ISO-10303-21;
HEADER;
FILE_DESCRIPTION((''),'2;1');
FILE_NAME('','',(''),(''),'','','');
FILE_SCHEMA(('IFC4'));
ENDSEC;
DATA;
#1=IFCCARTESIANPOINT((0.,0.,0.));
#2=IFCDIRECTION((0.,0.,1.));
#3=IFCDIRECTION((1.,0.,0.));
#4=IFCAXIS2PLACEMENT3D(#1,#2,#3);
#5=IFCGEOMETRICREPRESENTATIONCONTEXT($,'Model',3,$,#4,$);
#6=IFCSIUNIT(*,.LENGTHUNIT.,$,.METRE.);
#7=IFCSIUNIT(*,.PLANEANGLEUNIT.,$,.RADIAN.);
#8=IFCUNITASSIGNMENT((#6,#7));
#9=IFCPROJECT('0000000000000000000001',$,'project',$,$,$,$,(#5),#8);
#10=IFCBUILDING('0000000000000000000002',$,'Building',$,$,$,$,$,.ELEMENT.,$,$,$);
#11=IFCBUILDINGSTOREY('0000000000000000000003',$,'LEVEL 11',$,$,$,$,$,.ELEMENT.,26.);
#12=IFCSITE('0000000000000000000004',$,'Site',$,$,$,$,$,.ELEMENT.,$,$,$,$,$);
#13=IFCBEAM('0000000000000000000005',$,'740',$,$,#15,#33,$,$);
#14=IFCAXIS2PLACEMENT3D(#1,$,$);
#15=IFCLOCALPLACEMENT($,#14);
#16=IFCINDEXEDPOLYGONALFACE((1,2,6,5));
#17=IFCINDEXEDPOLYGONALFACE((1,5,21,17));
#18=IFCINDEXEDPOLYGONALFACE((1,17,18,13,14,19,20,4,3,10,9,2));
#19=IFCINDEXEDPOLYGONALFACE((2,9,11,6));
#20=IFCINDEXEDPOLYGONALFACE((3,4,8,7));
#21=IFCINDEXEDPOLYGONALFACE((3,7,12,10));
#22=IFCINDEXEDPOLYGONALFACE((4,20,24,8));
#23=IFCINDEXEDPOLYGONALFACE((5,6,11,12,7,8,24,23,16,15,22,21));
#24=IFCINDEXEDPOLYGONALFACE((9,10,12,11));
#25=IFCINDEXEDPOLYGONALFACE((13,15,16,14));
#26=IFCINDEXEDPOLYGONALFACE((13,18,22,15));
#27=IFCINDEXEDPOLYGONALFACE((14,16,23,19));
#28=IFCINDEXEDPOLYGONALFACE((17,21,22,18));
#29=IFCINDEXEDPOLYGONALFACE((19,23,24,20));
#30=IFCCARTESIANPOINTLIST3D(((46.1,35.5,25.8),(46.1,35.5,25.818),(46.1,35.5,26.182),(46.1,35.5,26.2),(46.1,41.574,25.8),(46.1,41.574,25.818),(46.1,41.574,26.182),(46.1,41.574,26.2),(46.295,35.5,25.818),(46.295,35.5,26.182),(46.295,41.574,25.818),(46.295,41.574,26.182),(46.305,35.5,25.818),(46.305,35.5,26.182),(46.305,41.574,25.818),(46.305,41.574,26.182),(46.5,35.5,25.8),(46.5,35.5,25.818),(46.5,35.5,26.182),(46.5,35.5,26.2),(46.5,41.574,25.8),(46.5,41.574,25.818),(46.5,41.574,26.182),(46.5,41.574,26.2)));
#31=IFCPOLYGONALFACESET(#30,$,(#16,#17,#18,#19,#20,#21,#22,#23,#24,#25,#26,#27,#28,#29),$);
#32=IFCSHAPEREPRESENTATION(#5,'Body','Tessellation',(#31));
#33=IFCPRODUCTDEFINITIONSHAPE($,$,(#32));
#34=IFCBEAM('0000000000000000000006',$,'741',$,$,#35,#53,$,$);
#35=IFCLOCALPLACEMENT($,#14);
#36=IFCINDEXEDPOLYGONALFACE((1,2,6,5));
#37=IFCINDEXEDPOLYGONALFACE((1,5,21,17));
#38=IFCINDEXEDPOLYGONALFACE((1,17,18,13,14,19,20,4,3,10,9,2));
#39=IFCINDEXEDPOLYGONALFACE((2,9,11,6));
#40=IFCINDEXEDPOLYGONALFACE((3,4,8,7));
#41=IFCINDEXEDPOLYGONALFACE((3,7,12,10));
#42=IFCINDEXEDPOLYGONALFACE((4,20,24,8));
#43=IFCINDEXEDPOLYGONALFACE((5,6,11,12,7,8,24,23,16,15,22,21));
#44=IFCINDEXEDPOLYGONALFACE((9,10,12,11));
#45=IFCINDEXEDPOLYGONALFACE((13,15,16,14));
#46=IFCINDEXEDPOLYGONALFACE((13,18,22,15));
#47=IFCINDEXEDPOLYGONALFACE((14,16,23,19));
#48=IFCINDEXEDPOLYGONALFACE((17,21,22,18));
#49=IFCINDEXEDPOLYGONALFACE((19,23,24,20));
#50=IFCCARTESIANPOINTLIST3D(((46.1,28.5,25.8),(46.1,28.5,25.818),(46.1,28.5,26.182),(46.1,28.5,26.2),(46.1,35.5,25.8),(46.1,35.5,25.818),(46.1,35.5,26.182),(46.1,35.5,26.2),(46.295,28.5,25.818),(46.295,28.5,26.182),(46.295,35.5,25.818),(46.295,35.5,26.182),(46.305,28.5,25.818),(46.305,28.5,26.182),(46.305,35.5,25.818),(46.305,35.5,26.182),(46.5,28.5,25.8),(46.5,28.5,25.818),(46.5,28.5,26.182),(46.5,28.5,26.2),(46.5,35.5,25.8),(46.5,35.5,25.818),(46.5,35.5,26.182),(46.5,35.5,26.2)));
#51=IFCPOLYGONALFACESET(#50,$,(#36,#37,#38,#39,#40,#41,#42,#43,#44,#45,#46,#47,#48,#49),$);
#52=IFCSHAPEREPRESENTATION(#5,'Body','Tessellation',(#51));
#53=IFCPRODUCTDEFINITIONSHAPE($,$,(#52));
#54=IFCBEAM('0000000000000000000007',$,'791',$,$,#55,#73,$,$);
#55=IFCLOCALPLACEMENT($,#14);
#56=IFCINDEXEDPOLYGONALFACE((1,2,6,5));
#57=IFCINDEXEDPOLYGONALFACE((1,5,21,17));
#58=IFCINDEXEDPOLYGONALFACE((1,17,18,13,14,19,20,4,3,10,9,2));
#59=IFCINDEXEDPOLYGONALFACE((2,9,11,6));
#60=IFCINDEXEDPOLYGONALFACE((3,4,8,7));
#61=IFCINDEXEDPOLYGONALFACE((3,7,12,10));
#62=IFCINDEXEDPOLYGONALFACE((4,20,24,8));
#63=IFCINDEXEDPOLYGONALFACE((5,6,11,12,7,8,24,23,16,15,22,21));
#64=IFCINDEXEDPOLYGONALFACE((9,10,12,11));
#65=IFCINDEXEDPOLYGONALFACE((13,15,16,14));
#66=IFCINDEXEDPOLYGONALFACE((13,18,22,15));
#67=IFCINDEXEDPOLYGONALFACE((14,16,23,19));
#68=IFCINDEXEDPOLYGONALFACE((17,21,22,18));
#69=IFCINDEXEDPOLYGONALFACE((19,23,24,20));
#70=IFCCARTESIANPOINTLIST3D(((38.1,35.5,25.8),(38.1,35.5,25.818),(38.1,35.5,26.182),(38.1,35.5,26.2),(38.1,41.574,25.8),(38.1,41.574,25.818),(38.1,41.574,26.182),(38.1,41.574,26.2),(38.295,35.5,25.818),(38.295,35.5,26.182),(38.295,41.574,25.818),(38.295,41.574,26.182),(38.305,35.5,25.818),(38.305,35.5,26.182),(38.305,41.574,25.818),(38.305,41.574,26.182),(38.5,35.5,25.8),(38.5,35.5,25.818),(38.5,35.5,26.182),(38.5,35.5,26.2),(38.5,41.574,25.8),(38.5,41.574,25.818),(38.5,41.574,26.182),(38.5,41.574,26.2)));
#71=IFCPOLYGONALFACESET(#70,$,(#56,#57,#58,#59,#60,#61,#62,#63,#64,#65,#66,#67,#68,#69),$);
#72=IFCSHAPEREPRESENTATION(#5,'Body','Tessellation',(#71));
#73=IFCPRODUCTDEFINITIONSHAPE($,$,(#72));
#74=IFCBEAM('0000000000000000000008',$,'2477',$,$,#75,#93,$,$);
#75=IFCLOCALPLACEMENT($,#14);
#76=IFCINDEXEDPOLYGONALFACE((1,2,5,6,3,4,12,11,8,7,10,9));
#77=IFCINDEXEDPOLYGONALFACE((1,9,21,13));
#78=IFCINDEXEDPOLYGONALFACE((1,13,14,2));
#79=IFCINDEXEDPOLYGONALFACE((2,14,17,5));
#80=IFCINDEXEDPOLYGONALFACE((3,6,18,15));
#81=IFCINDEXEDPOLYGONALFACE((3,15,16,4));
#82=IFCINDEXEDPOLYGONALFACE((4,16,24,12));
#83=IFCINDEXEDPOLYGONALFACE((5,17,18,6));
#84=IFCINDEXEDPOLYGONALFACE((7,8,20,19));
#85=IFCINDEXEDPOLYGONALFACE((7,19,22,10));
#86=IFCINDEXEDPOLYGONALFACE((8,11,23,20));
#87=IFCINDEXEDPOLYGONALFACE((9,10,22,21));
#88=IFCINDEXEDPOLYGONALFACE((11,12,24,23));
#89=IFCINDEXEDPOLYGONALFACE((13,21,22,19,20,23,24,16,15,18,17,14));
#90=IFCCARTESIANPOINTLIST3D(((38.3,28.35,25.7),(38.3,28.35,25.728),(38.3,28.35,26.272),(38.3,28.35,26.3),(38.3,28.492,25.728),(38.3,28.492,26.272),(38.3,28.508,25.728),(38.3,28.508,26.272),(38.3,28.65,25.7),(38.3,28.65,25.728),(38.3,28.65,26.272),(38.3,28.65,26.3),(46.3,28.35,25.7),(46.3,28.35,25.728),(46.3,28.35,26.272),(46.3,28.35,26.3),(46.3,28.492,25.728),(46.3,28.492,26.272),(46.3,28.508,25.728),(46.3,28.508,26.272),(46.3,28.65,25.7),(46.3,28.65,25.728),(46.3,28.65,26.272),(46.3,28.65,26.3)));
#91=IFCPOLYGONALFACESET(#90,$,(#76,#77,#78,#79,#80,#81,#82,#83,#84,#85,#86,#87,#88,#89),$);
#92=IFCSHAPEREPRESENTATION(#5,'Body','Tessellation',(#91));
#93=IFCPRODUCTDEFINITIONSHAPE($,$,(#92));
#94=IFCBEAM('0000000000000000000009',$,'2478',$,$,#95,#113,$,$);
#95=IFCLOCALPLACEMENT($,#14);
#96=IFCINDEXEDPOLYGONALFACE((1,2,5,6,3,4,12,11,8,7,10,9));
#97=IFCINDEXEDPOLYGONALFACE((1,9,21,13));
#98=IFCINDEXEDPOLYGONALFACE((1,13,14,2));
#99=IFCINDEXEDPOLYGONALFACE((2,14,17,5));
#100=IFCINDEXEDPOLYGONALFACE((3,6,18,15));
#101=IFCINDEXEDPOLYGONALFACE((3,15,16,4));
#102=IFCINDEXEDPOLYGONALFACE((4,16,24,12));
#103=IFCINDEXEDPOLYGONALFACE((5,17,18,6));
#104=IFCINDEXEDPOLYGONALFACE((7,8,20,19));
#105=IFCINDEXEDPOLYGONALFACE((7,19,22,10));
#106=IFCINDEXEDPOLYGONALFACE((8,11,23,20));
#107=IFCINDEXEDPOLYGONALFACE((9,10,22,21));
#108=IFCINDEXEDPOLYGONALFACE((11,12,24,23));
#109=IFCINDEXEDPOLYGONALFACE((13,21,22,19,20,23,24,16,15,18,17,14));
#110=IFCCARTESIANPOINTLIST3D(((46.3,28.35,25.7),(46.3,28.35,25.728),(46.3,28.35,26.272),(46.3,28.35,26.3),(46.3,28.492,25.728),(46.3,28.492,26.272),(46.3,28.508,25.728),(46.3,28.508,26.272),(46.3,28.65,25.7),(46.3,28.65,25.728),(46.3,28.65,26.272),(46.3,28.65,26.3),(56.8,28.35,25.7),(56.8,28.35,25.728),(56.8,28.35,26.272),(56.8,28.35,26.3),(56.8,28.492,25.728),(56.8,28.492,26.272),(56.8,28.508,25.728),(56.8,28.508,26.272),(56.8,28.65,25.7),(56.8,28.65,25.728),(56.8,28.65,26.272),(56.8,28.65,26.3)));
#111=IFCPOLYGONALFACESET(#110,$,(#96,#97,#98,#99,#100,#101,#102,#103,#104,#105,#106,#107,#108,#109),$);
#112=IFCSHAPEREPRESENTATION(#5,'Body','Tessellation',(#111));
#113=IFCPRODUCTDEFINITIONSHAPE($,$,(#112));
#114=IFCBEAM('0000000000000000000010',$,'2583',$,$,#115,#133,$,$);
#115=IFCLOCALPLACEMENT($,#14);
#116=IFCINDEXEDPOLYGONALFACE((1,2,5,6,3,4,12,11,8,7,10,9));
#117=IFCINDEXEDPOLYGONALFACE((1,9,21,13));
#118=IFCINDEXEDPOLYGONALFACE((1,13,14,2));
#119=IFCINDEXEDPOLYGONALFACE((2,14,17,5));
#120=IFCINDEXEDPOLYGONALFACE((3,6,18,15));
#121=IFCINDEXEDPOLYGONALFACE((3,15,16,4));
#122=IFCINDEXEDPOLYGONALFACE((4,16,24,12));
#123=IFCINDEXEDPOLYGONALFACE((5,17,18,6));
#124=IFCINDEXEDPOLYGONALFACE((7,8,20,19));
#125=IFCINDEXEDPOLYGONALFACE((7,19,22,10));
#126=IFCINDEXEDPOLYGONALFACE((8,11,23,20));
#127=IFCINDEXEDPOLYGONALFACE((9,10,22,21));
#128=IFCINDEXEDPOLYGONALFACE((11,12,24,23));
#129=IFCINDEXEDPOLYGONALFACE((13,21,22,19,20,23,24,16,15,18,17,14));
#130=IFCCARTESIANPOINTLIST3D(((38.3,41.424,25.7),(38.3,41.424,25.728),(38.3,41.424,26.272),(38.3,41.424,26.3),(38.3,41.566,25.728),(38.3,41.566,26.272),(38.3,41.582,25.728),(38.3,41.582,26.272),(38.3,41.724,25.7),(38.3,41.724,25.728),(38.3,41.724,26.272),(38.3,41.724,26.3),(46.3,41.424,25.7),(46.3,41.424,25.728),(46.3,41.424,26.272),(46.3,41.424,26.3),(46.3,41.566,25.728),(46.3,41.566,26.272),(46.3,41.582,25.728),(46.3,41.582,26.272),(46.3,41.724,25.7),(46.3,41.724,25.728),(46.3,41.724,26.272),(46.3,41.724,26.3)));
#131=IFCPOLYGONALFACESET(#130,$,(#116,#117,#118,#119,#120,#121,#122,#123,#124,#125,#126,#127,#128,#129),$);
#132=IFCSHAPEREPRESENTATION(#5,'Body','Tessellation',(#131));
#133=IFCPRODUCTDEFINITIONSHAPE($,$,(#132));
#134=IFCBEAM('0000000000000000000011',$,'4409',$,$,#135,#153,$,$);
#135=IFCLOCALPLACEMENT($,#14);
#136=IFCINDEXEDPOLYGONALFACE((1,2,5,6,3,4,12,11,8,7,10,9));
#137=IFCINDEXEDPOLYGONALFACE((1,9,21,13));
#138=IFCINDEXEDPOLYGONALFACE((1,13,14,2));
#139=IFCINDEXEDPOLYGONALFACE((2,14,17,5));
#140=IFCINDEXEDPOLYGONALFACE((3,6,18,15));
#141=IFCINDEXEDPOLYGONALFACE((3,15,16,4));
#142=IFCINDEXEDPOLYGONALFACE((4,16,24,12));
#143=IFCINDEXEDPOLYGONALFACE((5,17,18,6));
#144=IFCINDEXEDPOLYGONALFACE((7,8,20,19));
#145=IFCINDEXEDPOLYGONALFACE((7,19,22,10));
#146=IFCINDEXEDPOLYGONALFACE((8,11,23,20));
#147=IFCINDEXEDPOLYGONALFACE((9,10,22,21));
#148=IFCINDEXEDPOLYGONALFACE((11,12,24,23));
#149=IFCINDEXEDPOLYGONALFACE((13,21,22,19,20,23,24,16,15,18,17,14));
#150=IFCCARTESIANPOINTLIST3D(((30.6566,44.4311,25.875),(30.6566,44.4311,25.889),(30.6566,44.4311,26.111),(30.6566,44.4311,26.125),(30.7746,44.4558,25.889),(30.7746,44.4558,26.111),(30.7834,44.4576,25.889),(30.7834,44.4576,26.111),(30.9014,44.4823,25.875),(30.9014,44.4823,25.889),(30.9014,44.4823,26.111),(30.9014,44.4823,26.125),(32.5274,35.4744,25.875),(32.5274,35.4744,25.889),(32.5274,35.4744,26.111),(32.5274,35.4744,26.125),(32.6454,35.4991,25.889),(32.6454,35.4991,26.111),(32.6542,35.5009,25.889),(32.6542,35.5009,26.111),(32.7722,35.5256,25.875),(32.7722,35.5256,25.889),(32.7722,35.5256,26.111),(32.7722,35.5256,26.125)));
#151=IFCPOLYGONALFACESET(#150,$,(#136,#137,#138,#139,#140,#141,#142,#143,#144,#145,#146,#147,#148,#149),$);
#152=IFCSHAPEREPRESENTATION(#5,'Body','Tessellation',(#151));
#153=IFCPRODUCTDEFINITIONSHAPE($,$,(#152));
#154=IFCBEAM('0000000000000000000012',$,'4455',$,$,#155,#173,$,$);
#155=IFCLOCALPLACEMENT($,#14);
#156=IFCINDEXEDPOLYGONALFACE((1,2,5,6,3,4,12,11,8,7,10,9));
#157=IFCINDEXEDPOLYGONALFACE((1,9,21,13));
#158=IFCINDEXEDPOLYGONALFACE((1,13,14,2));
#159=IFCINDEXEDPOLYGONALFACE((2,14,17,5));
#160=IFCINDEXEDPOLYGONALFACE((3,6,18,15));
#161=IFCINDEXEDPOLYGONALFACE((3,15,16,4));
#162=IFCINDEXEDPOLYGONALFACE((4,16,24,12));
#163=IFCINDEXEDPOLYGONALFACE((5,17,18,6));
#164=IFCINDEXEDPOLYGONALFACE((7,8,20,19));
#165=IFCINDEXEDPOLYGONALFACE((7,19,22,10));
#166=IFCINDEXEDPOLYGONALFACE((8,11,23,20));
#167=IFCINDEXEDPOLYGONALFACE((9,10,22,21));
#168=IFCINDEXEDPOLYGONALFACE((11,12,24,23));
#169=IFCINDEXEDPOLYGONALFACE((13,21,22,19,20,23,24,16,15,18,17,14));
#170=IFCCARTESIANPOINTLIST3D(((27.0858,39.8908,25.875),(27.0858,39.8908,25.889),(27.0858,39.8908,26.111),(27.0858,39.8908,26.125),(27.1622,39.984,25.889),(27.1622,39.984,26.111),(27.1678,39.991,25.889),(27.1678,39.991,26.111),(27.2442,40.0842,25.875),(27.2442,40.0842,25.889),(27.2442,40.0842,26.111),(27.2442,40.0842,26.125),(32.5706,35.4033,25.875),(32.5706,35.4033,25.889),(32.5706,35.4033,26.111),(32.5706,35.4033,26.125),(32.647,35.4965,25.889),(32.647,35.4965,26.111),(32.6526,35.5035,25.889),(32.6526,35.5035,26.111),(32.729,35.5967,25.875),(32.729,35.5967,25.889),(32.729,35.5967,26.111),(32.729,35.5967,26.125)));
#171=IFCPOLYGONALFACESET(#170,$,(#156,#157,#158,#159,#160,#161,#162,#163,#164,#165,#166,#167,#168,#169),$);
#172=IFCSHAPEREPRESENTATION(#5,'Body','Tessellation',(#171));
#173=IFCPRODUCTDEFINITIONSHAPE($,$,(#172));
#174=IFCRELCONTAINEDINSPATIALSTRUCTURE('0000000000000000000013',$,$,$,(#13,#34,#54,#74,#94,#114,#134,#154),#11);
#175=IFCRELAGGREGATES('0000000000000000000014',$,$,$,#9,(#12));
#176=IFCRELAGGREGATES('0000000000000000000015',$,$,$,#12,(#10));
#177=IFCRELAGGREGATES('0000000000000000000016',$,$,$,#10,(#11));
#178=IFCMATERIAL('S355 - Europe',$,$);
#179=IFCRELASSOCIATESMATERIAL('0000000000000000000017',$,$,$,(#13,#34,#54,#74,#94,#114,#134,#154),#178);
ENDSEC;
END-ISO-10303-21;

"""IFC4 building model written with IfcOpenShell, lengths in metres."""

from ifc_helpers import new_model, si_unit, frame, origin_with_axes, origin_2d_with_axis, place, context, project, spatial, i_section, extrude, material, material_profile, profile_set, profile_usage, element, save


model = new_model("IFC4")

# Units and contexts
model_context = context("Model", 3, world=origin_with_axes())
ifc_project = project(units=[si_unit("LENGTHUNIT", "METRE"), si_unit("PLANEANGLEUNIT", "RADIAN")], contexts=[model_context])

# Site, building, storey
site = spatial("IfcSite", under=ifc_project, Name="Site", CompositionType="ELEMENT")
building = spatial("IfcBuilding", under=site, Name="Building", CompositionType="ELEMENT")
storey = spatial("IfcBuildingStorey", under=building, Name="LEVEL 11", CompositionType="ELEMENT", Elevation=26.0)

# Shared definitions
ifc_material = material(Name="S355 - Europe")

# Beams
ifc_material_profile_1 = material_profile(ifc_material, i_section(OverallWidth=0.4, OverallDepth=0.4, WebThickness=0.01, FlangeThickness=0.018, at=origin_2d_with_axis()))
ifc_profile_set_1 = profile_set([ifc_material_profile_1])
ifc_profile_usage_1 = profile_usage(ifc_profile_set_1, cardinal=10)
beam_1_placement = place(None, frame((46.3, 35.5, 26.0), z_axis=(0.0, 1.0, 0.0), x_axis=(-1.0, 0.0, 0.0)))
element("IfcBeam", 1, at=beam_1_placement, inside=storey, material=ifc_profile_usage_1, Name="740", context=model_context, shape_type="SweptSolid", body=[
    extrude(i_section(OverallWidth=0.4, OverallDepth=0.4, WebThickness=0.01, FlangeThickness=0.018, at=origin_2d_with_axis()), origin_with_axes(), (0.0, 0.0, 1.0), 6.074),
])
ifc_material_profile_2 = material_profile(ifc_material, i_section(OverallWidth=0.4, OverallDepth=0.4, WebThickness=0.01, FlangeThickness=0.018, at=origin_2d_with_axis()))
ifc_profile_set_2 = profile_set([ifc_material_profile_2])
ifc_profile_usage_2 = profile_usage(ifc_profile_set_2, cardinal=10)
beam_2_placement = place(None, frame((46.3, 28.5, 26.0), z_axis=(0.0, 1.0, 0.0), x_axis=(-1.0, 0.0, 0.0)))
element("IfcBeam", 2, at=beam_2_placement, inside=storey, material=ifc_profile_usage_2, Name="741", context=model_context, shape_type="SweptSolid", body=[
    extrude(i_section(OverallWidth=0.4, OverallDepth=0.4, WebThickness=0.01, FlangeThickness=0.018, at=origin_2d_with_axis()), origin_with_axes(), (0.0, 0.0, 1.0), 7.0),
])
ifc_material_profile_3 = material_profile(ifc_material, i_section(OverallWidth=0.4, OverallDepth=0.4, WebThickness=0.01, FlangeThickness=0.018, at=origin_2d_with_axis()))
ifc_profile_set_3 = profile_set([ifc_material_profile_3])
ifc_profile_usage_3 = profile_usage(ifc_profile_set_3, cardinal=10)
beam_3_placement = place(None, frame((38.3, 41.574, 26.0), z_axis=(0.0, -1.0, 0.0), x_axis=(1.0, 0.0, 0.0)))
element("IfcBeam", 3, at=beam_3_placement, inside=storey, material=ifc_profile_usage_3, Name="791", context=model_context, shape_type="SweptSolid", body=[
    extrude(i_section(OverallWidth=0.4, OverallDepth=0.4, WebThickness=0.01, FlangeThickness=0.018, at=origin_2d_with_axis()), origin_with_axes(), (0.0, 0.0, 1.0), 6.074),
])
ifc_material_profile_4 = material_profile(ifc_material, i_section(OverallWidth=0.3, OverallDepth=0.6, WebThickness=0.016, FlangeThickness=0.028, at=origin_2d_with_axis()))
ifc_profile_set_4 = profile_set([ifc_material_profile_4])
ifc_profile_usage_4 = profile_usage(ifc_profile_set_4, cardinal=10)
beam_4_placement = place(None, frame((38.3, 28.5, 26.0), z_axis=(1.0, 0.0, 0.0), x_axis=(0.0, 1.0, 0.0)))
element("IfcBeam", 4, at=beam_4_placement, inside=storey, material=ifc_profile_usage_4, Name="2477", context=model_context, shape_type="SweptSolid", body=[
    extrude(i_section(OverallWidth=0.3, OverallDepth=0.6, WebThickness=0.016, FlangeThickness=0.028, at=origin_2d_with_axis()), origin_with_axes(), (0.0, 0.0, 1.0), 8.0),
])
ifc_material_profile_5 = material_profile(ifc_material, i_section(OverallWidth=0.3, OverallDepth=0.6, WebThickness=0.016, FlangeThickness=0.028, at=origin_2d_with_axis()))
ifc_profile_set_5 = profile_set([ifc_material_profile_5])
ifc_profile_usage_5 = profile_usage(ifc_profile_set_5, cardinal=10)
beam_5_placement = place(None, frame((46.3, 28.5, 26.0), z_axis=(1.0, 0.0, 0.0), x_axis=(0.0, 1.0, 0.0)))
element("IfcBeam", 5, at=beam_5_placement, inside=storey, material=ifc_profile_usage_5, Name="2478", context=model_context, shape_type="SweptSolid", body=[
    extrude(i_section(OverallWidth=0.3, OverallDepth=0.6, WebThickness=0.016, FlangeThickness=0.028, at=origin_2d_with_axis()), origin_with_axes(), (0.0, 0.0, 1.0), 10.5),
])
ifc_material_profile_6 = material_profile(ifc_material, i_section(OverallWidth=0.3, OverallDepth=0.6, WebThickness=0.016, FlangeThickness=0.028, at=origin_2d_with_axis()))
ifc_profile_set_6 = profile_set([ifc_material_profile_6])
ifc_profile_usage_6 = profile_usage(ifc_profile_set_6, cardinal=10)
beam_6_placement = place(None, frame((38.3, 41.574, 26.0), z_axis=(1.0, 0.0, 0.0), x_axis=(0.0, 1.0, 0.0)))
element("IfcBeam", 6, at=beam_6_placement, inside=storey, material=ifc_profile_usage_6, Name="2583", context=model_context, shape_type="SweptSolid", body=[
    extrude(i_section(OverallWidth=0.3, OverallDepth=0.6, WebThickness=0.016, FlangeThickness=0.028, at=origin_2d_with_axis()), origin_with_axes(), (0.0, 0.0, 1.0), 8.0),
])
ifc_material_profile_7 = material_profile(ifc_material, i_section(OverallWidth=0.25, OverallDepth=0.25, WebThickness=0.009, FlangeThickness=0.014, at=origin_2d_with_axis()))
ifc_profile_set_7 = profile_set([ifc_material_profile_7])
ifc_profile_usage_7 = profile_usage(ifc_profile_set_7, cardinal=10)
beam_7_placement = place(None, frame((32.6498, 35.5, 26.0), z_axis=(-0.204459, 0.978875, 0.0), x_axis=(-0.978875, -0.204459, 0.0)))
element("IfcBeam", 7, at=beam_7_placement, inside=storey, material=ifc_profile_usage_7, Name="4409", context=model_context, shape_type="SweptSolid", body=[
    extrude(i_section(OverallWidth=0.25, OverallDepth=0.25, WebThickness=0.009, FlangeThickness=0.014, at=origin_2d_with_axis()), origin_with_axes(), (0.0, 0.0, 1.0), 9.15),
])
ifc_material_profile_8 = material_profile(ifc_material, i_section(OverallWidth=0.25, OverallDepth=0.25, WebThickness=0.009, FlangeThickness=0.014, at=origin_2d_with_axis()))
ifc_profile_set_8 = profile_set([ifc_material_profile_8])
ifc_profile_usage_8 = profile_usage(ifc_profile_set_8, cardinal=10)
beam_8_placement = place(None, frame((32.6498, 35.5, 26.0), z_axis=(-0.773962, 0.633232, 0.0), x_axis=(-0.633232, -0.773962, 0.0)))
element("IfcBeam", 8, at=beam_8_placement, inside=storey, material=ifc_profile_usage_8, Name="4455", context=model_context, shape_type="SweptSolid", body=[
    extrude(i_section(OverallWidth=0.25, OverallDepth=0.25, WebThickness=0.009, FlangeThickness=0.014, at=origin_2d_with_axis()), origin_with_axes(), (0.0, 0.0, 1.0), 7.0867),
])

save(model, "model.ifc")
